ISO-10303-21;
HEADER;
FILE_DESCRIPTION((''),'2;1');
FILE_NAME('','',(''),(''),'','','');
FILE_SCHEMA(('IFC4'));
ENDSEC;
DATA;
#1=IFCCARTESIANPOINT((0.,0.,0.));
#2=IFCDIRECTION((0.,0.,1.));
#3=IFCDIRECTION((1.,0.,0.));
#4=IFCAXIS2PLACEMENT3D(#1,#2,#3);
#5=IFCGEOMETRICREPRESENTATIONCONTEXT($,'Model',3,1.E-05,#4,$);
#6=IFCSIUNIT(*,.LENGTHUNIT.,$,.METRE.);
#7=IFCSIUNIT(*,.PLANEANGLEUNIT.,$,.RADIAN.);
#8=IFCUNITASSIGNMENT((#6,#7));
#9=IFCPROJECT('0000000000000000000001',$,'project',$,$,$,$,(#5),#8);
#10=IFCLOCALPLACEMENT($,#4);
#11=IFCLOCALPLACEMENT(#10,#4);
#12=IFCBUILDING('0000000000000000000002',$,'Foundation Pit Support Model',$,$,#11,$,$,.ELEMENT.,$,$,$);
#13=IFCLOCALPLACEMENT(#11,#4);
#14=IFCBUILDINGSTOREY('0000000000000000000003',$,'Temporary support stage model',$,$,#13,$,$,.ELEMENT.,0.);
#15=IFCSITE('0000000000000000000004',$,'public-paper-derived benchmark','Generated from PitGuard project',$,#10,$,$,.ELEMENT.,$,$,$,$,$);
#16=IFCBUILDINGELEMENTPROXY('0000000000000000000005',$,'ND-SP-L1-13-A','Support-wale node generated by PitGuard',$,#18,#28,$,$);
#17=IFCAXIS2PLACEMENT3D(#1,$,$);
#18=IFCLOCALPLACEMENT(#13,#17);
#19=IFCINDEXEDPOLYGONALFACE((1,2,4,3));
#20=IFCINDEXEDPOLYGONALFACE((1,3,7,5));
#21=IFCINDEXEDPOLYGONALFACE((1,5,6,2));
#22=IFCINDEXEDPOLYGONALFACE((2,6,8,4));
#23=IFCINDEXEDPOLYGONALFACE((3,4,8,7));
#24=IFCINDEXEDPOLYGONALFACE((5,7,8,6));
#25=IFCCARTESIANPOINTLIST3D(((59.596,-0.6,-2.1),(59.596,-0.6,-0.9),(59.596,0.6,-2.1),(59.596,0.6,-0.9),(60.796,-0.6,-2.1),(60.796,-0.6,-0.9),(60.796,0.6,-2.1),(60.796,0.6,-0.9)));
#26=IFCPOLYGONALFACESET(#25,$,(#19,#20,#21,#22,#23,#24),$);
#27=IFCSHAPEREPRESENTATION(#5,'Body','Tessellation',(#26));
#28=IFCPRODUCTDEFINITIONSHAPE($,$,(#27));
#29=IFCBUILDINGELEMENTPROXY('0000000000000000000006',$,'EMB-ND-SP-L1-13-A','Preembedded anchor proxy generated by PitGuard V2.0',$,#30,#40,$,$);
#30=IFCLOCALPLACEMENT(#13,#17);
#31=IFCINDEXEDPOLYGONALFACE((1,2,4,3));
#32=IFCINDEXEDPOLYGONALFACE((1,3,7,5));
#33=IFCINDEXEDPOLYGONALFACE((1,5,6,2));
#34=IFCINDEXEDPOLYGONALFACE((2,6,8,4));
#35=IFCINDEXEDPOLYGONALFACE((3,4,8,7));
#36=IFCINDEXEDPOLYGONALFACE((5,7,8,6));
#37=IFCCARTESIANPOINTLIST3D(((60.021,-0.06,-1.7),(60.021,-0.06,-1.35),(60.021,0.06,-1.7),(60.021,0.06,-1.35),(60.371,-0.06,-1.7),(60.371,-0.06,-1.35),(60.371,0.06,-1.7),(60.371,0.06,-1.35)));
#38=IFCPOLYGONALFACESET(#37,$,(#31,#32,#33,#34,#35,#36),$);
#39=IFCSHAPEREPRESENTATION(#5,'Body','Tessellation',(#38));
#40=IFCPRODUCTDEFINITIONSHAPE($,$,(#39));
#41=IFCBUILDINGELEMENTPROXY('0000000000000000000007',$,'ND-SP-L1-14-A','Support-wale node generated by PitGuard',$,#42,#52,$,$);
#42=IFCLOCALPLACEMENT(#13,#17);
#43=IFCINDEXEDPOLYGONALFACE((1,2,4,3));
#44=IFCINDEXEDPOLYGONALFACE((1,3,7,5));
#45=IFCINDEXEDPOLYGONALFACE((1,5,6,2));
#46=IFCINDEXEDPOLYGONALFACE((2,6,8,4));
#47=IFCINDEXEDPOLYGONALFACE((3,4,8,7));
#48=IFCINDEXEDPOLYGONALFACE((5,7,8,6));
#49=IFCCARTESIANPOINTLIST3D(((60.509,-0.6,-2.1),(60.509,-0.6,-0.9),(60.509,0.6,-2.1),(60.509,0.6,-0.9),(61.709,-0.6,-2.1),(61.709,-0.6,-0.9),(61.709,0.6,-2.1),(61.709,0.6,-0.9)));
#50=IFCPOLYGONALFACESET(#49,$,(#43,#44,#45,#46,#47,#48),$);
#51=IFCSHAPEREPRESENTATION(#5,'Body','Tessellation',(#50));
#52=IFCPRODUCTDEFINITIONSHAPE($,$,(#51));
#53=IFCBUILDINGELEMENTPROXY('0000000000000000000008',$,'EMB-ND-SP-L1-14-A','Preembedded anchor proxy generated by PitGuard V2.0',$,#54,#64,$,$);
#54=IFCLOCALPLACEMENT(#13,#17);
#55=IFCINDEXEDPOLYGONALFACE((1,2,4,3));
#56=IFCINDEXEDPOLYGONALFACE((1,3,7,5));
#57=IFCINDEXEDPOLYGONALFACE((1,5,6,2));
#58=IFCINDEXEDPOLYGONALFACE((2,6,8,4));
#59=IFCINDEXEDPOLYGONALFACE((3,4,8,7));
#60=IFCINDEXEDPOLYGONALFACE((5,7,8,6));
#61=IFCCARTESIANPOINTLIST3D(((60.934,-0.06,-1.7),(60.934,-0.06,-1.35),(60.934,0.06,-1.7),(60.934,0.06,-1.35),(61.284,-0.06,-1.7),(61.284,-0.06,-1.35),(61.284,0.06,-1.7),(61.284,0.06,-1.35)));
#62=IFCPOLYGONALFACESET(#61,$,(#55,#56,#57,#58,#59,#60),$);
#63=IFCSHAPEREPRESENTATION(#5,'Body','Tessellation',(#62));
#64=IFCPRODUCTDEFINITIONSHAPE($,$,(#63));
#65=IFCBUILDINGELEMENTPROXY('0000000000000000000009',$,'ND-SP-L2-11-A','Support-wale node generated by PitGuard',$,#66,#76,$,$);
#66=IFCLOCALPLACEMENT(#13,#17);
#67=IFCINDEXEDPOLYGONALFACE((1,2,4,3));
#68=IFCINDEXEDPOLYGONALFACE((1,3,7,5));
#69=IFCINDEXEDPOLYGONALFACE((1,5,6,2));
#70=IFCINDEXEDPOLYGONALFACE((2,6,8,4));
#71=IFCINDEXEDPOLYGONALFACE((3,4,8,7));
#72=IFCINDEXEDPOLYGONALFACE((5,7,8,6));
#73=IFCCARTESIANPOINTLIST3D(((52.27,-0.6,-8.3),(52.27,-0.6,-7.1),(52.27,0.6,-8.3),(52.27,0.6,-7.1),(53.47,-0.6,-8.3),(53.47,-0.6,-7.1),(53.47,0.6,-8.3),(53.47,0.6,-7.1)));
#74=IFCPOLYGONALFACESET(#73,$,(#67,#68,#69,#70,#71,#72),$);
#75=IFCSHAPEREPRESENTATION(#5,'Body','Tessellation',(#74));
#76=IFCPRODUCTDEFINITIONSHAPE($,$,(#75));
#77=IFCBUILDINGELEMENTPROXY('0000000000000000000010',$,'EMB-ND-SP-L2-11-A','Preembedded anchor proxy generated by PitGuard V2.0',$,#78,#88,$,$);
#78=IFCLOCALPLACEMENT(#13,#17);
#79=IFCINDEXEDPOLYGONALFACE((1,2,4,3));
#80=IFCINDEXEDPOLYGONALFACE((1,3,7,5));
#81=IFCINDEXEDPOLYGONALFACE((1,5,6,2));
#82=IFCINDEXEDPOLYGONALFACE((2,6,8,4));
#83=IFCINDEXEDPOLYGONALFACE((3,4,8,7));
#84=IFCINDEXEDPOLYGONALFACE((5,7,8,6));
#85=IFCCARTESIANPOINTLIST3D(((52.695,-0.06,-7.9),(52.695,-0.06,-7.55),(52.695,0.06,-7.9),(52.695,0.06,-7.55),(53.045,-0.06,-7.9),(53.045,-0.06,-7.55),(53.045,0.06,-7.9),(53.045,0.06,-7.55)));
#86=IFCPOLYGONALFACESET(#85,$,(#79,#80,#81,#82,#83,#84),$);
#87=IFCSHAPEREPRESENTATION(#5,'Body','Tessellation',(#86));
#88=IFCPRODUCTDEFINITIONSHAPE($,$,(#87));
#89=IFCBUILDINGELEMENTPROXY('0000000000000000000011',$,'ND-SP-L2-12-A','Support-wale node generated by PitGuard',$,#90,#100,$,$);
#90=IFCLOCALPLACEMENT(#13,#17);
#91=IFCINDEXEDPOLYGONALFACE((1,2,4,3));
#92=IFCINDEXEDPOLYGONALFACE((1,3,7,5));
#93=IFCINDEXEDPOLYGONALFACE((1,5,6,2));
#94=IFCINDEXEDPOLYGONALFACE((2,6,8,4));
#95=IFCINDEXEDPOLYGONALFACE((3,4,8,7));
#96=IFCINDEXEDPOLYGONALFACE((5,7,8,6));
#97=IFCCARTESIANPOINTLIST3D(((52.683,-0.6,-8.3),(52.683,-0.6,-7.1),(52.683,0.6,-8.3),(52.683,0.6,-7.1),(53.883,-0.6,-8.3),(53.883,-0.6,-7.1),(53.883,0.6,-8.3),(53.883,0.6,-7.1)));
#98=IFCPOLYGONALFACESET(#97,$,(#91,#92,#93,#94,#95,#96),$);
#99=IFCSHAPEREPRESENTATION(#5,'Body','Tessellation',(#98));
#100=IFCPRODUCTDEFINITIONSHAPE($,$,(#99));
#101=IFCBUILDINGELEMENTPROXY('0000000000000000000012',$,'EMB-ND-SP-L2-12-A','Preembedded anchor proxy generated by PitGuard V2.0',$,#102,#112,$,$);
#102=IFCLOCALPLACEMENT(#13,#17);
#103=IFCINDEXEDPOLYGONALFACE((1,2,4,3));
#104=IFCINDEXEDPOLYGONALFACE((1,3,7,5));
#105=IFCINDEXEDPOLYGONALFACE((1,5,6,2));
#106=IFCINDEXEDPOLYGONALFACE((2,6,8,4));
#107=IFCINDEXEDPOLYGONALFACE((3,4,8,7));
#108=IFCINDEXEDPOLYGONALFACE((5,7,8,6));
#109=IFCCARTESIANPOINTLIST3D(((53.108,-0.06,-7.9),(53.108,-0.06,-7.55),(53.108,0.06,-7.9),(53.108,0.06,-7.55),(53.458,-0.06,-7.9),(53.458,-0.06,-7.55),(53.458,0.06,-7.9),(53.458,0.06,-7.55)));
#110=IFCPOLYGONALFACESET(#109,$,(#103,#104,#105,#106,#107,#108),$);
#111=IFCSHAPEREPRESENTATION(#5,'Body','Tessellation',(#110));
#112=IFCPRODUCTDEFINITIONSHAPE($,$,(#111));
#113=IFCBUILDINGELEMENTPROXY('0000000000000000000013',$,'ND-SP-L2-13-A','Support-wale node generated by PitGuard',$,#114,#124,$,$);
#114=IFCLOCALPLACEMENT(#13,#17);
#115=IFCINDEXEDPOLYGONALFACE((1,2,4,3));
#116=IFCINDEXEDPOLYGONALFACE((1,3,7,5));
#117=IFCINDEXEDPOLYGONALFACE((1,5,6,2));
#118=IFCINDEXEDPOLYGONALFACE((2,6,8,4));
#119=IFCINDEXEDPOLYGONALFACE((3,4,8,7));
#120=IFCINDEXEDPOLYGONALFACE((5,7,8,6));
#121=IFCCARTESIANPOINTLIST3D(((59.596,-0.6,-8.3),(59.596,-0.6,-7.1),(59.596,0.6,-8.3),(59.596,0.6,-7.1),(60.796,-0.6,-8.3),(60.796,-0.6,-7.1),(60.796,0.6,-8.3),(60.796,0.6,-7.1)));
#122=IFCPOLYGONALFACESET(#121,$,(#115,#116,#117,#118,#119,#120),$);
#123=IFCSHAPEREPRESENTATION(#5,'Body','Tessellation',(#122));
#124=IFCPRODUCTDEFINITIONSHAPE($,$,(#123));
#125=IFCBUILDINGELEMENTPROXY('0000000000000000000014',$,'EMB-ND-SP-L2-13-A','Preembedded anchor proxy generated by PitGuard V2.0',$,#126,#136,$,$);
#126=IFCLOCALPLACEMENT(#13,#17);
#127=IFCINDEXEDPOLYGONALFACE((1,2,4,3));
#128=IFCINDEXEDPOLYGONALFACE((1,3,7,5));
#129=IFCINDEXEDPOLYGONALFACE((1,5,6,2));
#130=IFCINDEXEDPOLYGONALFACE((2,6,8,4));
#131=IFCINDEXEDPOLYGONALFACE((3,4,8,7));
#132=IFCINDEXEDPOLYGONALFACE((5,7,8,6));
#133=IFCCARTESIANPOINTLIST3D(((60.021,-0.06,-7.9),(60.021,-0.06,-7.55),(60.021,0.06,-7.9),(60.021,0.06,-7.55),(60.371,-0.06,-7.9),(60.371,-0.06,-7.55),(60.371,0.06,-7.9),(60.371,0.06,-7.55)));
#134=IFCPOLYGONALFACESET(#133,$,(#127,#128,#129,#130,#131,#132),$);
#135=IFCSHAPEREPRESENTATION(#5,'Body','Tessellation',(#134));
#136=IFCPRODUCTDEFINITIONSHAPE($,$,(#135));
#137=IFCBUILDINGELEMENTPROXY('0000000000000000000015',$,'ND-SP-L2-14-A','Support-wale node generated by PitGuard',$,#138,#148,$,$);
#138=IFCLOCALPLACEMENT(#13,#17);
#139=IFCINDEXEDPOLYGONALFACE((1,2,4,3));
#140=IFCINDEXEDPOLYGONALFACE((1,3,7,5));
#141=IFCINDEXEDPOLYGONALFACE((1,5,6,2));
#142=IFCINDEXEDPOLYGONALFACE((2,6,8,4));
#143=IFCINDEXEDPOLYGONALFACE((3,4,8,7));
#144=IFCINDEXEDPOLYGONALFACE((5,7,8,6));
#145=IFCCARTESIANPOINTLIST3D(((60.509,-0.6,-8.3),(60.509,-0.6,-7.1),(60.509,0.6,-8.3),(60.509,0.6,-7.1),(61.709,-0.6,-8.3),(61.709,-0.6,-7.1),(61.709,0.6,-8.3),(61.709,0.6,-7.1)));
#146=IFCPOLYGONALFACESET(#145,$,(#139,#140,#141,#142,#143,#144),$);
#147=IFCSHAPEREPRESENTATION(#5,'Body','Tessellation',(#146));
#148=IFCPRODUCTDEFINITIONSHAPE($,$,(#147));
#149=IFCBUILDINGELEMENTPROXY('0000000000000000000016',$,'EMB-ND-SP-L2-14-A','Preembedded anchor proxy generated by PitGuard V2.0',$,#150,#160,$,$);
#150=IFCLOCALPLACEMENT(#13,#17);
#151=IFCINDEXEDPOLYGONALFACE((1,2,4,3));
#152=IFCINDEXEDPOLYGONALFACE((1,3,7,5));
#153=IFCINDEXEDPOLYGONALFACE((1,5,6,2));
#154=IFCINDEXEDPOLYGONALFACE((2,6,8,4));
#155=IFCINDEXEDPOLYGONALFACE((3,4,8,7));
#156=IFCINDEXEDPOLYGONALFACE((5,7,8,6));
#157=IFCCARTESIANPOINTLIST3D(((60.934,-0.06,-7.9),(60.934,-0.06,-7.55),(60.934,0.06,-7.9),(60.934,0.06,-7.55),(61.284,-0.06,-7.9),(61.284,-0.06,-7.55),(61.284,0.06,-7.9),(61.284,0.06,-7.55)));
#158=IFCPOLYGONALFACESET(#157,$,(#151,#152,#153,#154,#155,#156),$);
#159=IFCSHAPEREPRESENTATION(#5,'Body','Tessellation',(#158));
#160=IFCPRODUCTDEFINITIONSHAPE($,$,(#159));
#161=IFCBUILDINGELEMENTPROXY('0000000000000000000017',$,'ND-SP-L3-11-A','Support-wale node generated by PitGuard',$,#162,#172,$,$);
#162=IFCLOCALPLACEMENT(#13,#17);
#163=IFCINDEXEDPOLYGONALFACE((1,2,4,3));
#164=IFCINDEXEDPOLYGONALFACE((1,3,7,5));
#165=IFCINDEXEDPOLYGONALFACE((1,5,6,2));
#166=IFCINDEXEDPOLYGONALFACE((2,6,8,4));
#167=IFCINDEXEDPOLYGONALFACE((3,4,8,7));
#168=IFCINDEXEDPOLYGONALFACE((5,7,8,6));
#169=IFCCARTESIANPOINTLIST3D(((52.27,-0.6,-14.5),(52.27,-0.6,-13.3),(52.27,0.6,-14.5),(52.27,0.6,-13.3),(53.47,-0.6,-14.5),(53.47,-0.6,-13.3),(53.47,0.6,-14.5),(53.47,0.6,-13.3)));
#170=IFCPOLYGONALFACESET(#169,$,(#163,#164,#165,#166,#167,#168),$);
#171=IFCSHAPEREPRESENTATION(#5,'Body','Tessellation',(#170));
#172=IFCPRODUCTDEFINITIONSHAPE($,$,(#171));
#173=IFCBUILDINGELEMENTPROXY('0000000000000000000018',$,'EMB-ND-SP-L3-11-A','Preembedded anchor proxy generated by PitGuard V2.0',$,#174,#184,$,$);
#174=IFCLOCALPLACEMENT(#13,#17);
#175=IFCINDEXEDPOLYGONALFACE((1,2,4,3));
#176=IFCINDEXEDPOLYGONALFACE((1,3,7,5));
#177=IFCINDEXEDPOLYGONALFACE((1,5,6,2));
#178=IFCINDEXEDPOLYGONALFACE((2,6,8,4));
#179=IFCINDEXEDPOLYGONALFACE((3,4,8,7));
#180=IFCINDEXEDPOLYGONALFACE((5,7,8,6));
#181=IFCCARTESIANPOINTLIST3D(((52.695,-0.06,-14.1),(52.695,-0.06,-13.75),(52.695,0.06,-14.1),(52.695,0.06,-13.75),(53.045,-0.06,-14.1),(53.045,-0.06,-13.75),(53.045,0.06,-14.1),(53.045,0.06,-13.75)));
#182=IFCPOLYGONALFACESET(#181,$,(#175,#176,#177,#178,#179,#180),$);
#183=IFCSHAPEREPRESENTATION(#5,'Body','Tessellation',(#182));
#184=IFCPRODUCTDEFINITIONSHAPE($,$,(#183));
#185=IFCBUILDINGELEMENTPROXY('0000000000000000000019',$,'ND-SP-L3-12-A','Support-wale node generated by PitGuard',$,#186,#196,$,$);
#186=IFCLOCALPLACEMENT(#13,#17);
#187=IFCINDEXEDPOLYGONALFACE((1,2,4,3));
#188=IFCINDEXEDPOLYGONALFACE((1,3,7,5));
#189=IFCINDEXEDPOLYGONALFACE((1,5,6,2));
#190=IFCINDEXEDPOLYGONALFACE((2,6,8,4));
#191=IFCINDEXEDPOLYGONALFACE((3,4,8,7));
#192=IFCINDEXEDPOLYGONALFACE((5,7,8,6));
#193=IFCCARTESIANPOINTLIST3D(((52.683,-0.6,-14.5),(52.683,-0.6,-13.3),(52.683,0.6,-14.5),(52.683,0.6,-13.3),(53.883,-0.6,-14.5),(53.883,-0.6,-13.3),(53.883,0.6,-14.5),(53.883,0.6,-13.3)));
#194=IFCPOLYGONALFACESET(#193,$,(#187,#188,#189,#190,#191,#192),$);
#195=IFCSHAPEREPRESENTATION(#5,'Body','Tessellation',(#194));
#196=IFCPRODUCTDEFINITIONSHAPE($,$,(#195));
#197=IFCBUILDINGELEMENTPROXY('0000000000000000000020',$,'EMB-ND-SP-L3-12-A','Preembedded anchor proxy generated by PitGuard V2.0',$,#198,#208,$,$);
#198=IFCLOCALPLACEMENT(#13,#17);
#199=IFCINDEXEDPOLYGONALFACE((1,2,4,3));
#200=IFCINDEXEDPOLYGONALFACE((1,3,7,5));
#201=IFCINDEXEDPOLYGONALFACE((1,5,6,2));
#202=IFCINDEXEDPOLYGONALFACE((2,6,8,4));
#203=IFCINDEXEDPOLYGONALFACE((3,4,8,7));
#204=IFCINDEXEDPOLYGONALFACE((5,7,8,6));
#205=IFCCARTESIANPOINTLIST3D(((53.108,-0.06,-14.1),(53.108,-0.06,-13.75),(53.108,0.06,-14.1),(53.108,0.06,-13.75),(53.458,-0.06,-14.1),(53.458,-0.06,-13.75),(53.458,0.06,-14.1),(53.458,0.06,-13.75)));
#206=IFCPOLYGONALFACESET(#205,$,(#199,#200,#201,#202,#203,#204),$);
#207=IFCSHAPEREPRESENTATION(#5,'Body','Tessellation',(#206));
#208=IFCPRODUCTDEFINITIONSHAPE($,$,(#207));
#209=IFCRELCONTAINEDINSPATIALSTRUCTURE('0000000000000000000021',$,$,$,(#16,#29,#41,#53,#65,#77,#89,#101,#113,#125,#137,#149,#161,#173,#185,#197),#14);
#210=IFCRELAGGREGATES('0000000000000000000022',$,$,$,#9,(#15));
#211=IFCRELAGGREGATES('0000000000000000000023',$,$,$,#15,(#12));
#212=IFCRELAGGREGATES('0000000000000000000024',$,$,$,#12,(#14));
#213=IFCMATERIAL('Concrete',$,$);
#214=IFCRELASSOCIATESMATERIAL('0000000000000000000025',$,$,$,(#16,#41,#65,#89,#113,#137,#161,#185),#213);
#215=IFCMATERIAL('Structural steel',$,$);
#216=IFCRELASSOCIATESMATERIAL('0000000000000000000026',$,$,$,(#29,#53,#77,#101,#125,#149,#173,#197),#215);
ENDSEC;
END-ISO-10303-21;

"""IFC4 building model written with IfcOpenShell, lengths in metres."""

from ifc_helpers import new_model, si_unit, frame, origin_with_axes, origin_2d, place, context, project, spatial, rectangle, extrude, material, element, save


model = new_model("IFC4")

# Units and contexts
model_context = context("Model", 3, precision=1e-05, world=origin_with_axes())
ifc_project = project(units=[si_unit("LENGTHUNIT", "METRE"), si_unit("PLANEANGLEUNIT", "RADIAN")], contexts=[model_context])

# Site, building, storey
site_placement = place(None, origin_with_axes())
site = spatial("IfcSite", under=ifc_project, at=site_placement, Name="public-paper-derived benchmark", Description="Generated from PitGuard project", CompositionType="ELEMENT")
building_placement = place(site_placement, origin_with_axes())
building = spatial("IfcBuilding", under=site, at=building_placement, Name="Foundation Pit Support Model", CompositionType="ELEMENT")
storey_placement = place(building_placement, origin_with_axes())
storey = spatial("IfcBuildingStorey", under=building, at=storey_placement, Name="Temporary support stage model", CompositionType="ELEMENT", Elevation=0.0)

# Shared definitions
ifc_material_1 = material(Name="Concrete")

# Shared definitions
ifc_material_2 = material(Name="Structural steel")

# Building element proxies
proxy_1_placement = place(storey_placement, frame((60.196, 0.0, -2.1), z_axis=(0.0, 0.0, 1.0), x_axis=(1.0, 0.0, 0.0)))
element("IfcBuildingElementProxy", 1, at=proxy_1_placement, inside=storey, material=ifc_material_1, Name="ND-SP-L1-13-A", Description="Support-wale node generated by PitGuard", context=model_context, shape_type="SweptSolid", body=[
    extrude(rectangle(XDim=1.2, YDim=1.2, at=origin_2d()), origin_with_axes(), (0.0, 0.0, 1.0), 1.2),
])
proxy_2_placement = place(storey_placement, frame((60.196, 0.0, -1.7), z_axis=(0.0, 0.0, 1.0), x_axis=(1.0, 0.0, 0.0)))
element("IfcBuildingElementProxy", 2, at=proxy_2_placement, inside=storey, material=ifc_material_2, Name="EMB-ND-SP-L1-13-A", Description="Preembedded anchor proxy generated by PitGuard V2.0", context=model_context, shape_type="SweptSolid", body=[
    extrude(rectangle(XDim=0.35, YDim=0.12, at=origin_2d()), origin_with_axes(), (0.0, 0.0, 1.0), 0.35),
])
proxy_3_placement = place(storey_placement, frame((61.109, 0.0, -2.1), z_axis=(0.0, 0.0, 1.0), x_axis=(1.0, 0.0, 0.0)))
element("IfcBuildingElementProxy", 3, at=proxy_3_placement, inside=storey, material=ifc_material_1, Name="ND-SP-L1-14-A", Description="Support-wale node generated by PitGuard", context=model_context, shape_type="SweptSolid", body=[
    extrude(rectangle(XDim=1.2, YDim=1.2, at=origin_2d()), origin_with_axes(), (0.0, 0.0, 1.0), 1.2),
])
proxy_4_placement = place(storey_placement, frame((61.109, 0.0, -1.7), z_axis=(0.0, 0.0, 1.0), x_axis=(1.0, 0.0, 0.0)))
element("IfcBuildingElementProxy", 4, at=proxy_4_placement, inside=storey, material=ifc_material_2, Name="EMB-ND-SP-L1-14-A", Description="Preembedded anchor proxy generated by PitGuard V2.0", context=model_context, shape_type="SweptSolid", body=[
    extrude(rectangle(XDim=0.35, YDim=0.12, at=origin_2d()), origin_with_axes(), (0.0, 0.0, 1.0), 0.35),
])
proxy_5_placement = place(storey_placement, frame((52.87, 0.0, -8.3), z_axis=(0.0, 0.0, 1.0), x_axis=(1.0, 0.0, 0.0)))
element("IfcBuildingElementProxy", 5, at=proxy_5_placement, inside=storey, material=ifc_material_1, Name="ND-SP-L2-11-A", Description="Support-wale node generated by PitGuard", context=model_context, shape_type="SweptSolid", body=[
    extrude(rectangle(XDim=1.2, YDim=1.2, at=origin_2d()), origin_with_axes(), (0.0, 0.0, 1.0), 1.2),
])
proxy_6_placement = place(storey_placement, frame((52.87, 0.0, -7.9), z_axis=(0.0, 0.0, 1.0), x_axis=(1.0, 0.0, 0.0)))
element("IfcBuildingElementProxy", 6, at=proxy_6_placement, inside=storey, material=ifc_material_2, Name="EMB-ND-SP-L2-11-A", Description="Preembedded anchor proxy generated by PitGuard V2.0", context=model_context, shape_type="SweptSolid", body=[
    extrude(rectangle(XDim=0.35, YDim=0.12, at=origin_2d()), origin_with_axes(), (0.0, 0.0, 1.0), 0.35),
])
proxy_7_placement = place(storey_placement, frame((53.283, 0.0, -8.3), z_axis=(0.0, 0.0, 1.0), x_axis=(1.0, 0.0, 0.0)))
element("IfcBuildingElementProxy", 7, at=proxy_7_placement, inside=storey, material=ifc_material_1, Name="ND-SP-L2-12-A", Description="Support-wale node generated by PitGuard", context=model_context, shape_type="SweptSolid", body=[
    extrude(rectangle(XDim=1.2, YDim=1.2, at=origin_2d()), origin_with_axes(), (0.0, 0.0, 1.0), 1.2),
])
proxy_8_placement = place(storey_placement, frame((53.283, 0.0, -7.9), z_axis=(0.0, 0.0, 1.0), x_axis=(1.0, 0.0, 0.0)))
element("IfcBuildingElementProxy", 8, at=proxy_8_placement, inside=storey, material=ifc_material_2, Name="EMB-ND-SP-L2-12-A", Description="Preembedded anchor proxy generated by PitGuard V2.0", context=model_context, shape_type="SweptSolid", body=[
    extrude(rectangle(XDim=0.35, YDim=0.12, at=origin_2d()), origin_with_axes(), (0.0, 0.0, 1.0), 0.35),
])
proxy_9_placement = place(storey_placement, frame((60.196, 0.0, -8.3), z_axis=(0.0, 0.0, 1.0), x_axis=(1.0, 0.0, 0.0)))
element("IfcBuildingElementProxy", 9, at=proxy_9_placement, inside=storey, material=ifc_material_1, Name="ND-SP-L2-13-A", Description="Support-wale node generated by PitGuard", context=model_context, shape_type="SweptSolid", body=[
    extrude(rectangle(XDim=1.2, YDim=1.2, at=origin_2d()), origin_with_axes(), (0.0, 0.0, 1.0), 1.2),
])
proxy_10_placement = place(storey_placement, frame((60.196, 0.0, -7.9), z_axis=(0.0, 0.0, 1.0), x_axis=(1.0, 0.0, 0.0)))
element("IfcBuildingElementProxy", 10, at=proxy_10_placement, inside=storey, material=ifc_material_2, Name="EMB-ND-SP-L2-13-A", Description="Preembedded anchor proxy generated by PitGuard V2.0", context=model_context, shape_type="SweptSolid", body=[
    extrude(rectangle(XDim=0.35, YDim=0.12, at=origin_2d()), origin_with_axes(), (0.0, 0.0, 1.0), 0.35),
])
proxy_11_placement = place(storey_placement, frame((61.109, 0.0, -8.3), z_axis=(0.0, 0.0, 1.0), x_axis=(1.0, 0.0, 0.0)))
element("IfcBuildingElementProxy", 11, at=proxy_11_placement, inside=storey, material=ifc_material_1, Name="ND-SP-L2-14-A", Description="Support-wale node generated by PitGuard", context=model_context, shape_type="SweptSolid", body=[
    extrude(rectangle(XDim=1.2, YDim=1.2, at=origin_2d()), origin_with_axes(), (0.0, 0.0, 1.0), 1.2),
])
proxy_12_placement = place(storey_placement, frame((61.109, 0.0, -7.9), z_axis=(0.0, 0.0, 1.0), x_axis=(1.0, 0.0, 0.0)))
element("IfcBuildingElementProxy", 12, at=proxy_12_placement, inside=storey, material=ifc_material_2, Name="EMB-ND-SP-L2-14-A", Description="Preembedded anchor proxy generated by PitGuard V2.0", context=model_context, shape_type="SweptSolid", body=[
    extrude(rectangle(XDim=0.35, YDim=0.12, at=origin_2d()), origin_with_axes(), (0.0, 0.0, 1.0), 0.35),
])
proxy_13_placement = place(storey_placement, frame((52.87, 0.0, -14.5), z_axis=(0.0, 0.0, 1.0), x_axis=(1.0, 0.0, 0.0)))
element("IfcBuildingElementProxy", 13, at=proxy_13_placement, inside=storey, material=ifc_material_1, Name="ND-SP-L3-11-A", Description="Support-wale node generated by PitGuard", context=model_context, shape_type="SweptSolid", body=[
    extrude(rectangle(XDim=1.2, YDim=1.2, at=origin_2d()), origin_with_axes(), (0.0, 0.0, 1.0), 1.2),
])
proxy_14_placement = place(storey_placement, frame((52.87, 0.0, -14.1), z_axis=(0.0, 0.0, 1.0), x_axis=(1.0, 0.0, 0.0)))
element("IfcBuildingElementProxy", 14, at=proxy_14_placement, inside=storey, material=ifc_material_2, Name="EMB-ND-SP-L3-11-A", Description="Preembedded anchor proxy generated by PitGuard V2.0", context=model_context, shape_type="SweptSolid", body=[
    extrude(rectangle(XDim=0.35, YDim=0.12, at=origin_2d()), origin_with_axes(), (0.0, 0.0, 1.0), 0.35),
])
proxy_15_placement = place(storey_placement, frame((53.283, 0.0, -14.5), z_axis=(0.0, 0.0, 1.0), x_axis=(1.0, 0.0, 0.0)))
element("IfcBuildingElementProxy", 15, at=proxy_15_placement, inside=storey, material=ifc_material_1, Name="ND-SP-L3-12-A", Description="Support-wale node generated by PitGuard", context=model_context, shape_type="SweptSolid", body=[
    extrude(rectangle(XDim=1.2, YDim=1.2, at=origin_2d()), origin_with_axes(), (0.0, 0.0, 1.0), 1.2),
])
proxy_16_placement = place(storey_placement, frame((53.283, 0.0, -14.1), z_axis=(0.0, 0.0, 1.0), x_axis=(1.0, 0.0, 0.0)))
element("IfcBuildingElementProxy", 16, at=proxy_16_placement, inside=storey, material=ifc_material_2, Name="EMB-ND-SP-L3-12-A", Description="Preembedded anchor proxy generated by PitGuard V2.0", context=model_context, shape_type="SweptSolid", body=[
    extrude(rectangle(XDim=0.35, YDim=0.12, at=origin_2d()), origin_with_axes(), (0.0, 0.0, 1.0), 0.35),
])

save(model, "model.ifc")
